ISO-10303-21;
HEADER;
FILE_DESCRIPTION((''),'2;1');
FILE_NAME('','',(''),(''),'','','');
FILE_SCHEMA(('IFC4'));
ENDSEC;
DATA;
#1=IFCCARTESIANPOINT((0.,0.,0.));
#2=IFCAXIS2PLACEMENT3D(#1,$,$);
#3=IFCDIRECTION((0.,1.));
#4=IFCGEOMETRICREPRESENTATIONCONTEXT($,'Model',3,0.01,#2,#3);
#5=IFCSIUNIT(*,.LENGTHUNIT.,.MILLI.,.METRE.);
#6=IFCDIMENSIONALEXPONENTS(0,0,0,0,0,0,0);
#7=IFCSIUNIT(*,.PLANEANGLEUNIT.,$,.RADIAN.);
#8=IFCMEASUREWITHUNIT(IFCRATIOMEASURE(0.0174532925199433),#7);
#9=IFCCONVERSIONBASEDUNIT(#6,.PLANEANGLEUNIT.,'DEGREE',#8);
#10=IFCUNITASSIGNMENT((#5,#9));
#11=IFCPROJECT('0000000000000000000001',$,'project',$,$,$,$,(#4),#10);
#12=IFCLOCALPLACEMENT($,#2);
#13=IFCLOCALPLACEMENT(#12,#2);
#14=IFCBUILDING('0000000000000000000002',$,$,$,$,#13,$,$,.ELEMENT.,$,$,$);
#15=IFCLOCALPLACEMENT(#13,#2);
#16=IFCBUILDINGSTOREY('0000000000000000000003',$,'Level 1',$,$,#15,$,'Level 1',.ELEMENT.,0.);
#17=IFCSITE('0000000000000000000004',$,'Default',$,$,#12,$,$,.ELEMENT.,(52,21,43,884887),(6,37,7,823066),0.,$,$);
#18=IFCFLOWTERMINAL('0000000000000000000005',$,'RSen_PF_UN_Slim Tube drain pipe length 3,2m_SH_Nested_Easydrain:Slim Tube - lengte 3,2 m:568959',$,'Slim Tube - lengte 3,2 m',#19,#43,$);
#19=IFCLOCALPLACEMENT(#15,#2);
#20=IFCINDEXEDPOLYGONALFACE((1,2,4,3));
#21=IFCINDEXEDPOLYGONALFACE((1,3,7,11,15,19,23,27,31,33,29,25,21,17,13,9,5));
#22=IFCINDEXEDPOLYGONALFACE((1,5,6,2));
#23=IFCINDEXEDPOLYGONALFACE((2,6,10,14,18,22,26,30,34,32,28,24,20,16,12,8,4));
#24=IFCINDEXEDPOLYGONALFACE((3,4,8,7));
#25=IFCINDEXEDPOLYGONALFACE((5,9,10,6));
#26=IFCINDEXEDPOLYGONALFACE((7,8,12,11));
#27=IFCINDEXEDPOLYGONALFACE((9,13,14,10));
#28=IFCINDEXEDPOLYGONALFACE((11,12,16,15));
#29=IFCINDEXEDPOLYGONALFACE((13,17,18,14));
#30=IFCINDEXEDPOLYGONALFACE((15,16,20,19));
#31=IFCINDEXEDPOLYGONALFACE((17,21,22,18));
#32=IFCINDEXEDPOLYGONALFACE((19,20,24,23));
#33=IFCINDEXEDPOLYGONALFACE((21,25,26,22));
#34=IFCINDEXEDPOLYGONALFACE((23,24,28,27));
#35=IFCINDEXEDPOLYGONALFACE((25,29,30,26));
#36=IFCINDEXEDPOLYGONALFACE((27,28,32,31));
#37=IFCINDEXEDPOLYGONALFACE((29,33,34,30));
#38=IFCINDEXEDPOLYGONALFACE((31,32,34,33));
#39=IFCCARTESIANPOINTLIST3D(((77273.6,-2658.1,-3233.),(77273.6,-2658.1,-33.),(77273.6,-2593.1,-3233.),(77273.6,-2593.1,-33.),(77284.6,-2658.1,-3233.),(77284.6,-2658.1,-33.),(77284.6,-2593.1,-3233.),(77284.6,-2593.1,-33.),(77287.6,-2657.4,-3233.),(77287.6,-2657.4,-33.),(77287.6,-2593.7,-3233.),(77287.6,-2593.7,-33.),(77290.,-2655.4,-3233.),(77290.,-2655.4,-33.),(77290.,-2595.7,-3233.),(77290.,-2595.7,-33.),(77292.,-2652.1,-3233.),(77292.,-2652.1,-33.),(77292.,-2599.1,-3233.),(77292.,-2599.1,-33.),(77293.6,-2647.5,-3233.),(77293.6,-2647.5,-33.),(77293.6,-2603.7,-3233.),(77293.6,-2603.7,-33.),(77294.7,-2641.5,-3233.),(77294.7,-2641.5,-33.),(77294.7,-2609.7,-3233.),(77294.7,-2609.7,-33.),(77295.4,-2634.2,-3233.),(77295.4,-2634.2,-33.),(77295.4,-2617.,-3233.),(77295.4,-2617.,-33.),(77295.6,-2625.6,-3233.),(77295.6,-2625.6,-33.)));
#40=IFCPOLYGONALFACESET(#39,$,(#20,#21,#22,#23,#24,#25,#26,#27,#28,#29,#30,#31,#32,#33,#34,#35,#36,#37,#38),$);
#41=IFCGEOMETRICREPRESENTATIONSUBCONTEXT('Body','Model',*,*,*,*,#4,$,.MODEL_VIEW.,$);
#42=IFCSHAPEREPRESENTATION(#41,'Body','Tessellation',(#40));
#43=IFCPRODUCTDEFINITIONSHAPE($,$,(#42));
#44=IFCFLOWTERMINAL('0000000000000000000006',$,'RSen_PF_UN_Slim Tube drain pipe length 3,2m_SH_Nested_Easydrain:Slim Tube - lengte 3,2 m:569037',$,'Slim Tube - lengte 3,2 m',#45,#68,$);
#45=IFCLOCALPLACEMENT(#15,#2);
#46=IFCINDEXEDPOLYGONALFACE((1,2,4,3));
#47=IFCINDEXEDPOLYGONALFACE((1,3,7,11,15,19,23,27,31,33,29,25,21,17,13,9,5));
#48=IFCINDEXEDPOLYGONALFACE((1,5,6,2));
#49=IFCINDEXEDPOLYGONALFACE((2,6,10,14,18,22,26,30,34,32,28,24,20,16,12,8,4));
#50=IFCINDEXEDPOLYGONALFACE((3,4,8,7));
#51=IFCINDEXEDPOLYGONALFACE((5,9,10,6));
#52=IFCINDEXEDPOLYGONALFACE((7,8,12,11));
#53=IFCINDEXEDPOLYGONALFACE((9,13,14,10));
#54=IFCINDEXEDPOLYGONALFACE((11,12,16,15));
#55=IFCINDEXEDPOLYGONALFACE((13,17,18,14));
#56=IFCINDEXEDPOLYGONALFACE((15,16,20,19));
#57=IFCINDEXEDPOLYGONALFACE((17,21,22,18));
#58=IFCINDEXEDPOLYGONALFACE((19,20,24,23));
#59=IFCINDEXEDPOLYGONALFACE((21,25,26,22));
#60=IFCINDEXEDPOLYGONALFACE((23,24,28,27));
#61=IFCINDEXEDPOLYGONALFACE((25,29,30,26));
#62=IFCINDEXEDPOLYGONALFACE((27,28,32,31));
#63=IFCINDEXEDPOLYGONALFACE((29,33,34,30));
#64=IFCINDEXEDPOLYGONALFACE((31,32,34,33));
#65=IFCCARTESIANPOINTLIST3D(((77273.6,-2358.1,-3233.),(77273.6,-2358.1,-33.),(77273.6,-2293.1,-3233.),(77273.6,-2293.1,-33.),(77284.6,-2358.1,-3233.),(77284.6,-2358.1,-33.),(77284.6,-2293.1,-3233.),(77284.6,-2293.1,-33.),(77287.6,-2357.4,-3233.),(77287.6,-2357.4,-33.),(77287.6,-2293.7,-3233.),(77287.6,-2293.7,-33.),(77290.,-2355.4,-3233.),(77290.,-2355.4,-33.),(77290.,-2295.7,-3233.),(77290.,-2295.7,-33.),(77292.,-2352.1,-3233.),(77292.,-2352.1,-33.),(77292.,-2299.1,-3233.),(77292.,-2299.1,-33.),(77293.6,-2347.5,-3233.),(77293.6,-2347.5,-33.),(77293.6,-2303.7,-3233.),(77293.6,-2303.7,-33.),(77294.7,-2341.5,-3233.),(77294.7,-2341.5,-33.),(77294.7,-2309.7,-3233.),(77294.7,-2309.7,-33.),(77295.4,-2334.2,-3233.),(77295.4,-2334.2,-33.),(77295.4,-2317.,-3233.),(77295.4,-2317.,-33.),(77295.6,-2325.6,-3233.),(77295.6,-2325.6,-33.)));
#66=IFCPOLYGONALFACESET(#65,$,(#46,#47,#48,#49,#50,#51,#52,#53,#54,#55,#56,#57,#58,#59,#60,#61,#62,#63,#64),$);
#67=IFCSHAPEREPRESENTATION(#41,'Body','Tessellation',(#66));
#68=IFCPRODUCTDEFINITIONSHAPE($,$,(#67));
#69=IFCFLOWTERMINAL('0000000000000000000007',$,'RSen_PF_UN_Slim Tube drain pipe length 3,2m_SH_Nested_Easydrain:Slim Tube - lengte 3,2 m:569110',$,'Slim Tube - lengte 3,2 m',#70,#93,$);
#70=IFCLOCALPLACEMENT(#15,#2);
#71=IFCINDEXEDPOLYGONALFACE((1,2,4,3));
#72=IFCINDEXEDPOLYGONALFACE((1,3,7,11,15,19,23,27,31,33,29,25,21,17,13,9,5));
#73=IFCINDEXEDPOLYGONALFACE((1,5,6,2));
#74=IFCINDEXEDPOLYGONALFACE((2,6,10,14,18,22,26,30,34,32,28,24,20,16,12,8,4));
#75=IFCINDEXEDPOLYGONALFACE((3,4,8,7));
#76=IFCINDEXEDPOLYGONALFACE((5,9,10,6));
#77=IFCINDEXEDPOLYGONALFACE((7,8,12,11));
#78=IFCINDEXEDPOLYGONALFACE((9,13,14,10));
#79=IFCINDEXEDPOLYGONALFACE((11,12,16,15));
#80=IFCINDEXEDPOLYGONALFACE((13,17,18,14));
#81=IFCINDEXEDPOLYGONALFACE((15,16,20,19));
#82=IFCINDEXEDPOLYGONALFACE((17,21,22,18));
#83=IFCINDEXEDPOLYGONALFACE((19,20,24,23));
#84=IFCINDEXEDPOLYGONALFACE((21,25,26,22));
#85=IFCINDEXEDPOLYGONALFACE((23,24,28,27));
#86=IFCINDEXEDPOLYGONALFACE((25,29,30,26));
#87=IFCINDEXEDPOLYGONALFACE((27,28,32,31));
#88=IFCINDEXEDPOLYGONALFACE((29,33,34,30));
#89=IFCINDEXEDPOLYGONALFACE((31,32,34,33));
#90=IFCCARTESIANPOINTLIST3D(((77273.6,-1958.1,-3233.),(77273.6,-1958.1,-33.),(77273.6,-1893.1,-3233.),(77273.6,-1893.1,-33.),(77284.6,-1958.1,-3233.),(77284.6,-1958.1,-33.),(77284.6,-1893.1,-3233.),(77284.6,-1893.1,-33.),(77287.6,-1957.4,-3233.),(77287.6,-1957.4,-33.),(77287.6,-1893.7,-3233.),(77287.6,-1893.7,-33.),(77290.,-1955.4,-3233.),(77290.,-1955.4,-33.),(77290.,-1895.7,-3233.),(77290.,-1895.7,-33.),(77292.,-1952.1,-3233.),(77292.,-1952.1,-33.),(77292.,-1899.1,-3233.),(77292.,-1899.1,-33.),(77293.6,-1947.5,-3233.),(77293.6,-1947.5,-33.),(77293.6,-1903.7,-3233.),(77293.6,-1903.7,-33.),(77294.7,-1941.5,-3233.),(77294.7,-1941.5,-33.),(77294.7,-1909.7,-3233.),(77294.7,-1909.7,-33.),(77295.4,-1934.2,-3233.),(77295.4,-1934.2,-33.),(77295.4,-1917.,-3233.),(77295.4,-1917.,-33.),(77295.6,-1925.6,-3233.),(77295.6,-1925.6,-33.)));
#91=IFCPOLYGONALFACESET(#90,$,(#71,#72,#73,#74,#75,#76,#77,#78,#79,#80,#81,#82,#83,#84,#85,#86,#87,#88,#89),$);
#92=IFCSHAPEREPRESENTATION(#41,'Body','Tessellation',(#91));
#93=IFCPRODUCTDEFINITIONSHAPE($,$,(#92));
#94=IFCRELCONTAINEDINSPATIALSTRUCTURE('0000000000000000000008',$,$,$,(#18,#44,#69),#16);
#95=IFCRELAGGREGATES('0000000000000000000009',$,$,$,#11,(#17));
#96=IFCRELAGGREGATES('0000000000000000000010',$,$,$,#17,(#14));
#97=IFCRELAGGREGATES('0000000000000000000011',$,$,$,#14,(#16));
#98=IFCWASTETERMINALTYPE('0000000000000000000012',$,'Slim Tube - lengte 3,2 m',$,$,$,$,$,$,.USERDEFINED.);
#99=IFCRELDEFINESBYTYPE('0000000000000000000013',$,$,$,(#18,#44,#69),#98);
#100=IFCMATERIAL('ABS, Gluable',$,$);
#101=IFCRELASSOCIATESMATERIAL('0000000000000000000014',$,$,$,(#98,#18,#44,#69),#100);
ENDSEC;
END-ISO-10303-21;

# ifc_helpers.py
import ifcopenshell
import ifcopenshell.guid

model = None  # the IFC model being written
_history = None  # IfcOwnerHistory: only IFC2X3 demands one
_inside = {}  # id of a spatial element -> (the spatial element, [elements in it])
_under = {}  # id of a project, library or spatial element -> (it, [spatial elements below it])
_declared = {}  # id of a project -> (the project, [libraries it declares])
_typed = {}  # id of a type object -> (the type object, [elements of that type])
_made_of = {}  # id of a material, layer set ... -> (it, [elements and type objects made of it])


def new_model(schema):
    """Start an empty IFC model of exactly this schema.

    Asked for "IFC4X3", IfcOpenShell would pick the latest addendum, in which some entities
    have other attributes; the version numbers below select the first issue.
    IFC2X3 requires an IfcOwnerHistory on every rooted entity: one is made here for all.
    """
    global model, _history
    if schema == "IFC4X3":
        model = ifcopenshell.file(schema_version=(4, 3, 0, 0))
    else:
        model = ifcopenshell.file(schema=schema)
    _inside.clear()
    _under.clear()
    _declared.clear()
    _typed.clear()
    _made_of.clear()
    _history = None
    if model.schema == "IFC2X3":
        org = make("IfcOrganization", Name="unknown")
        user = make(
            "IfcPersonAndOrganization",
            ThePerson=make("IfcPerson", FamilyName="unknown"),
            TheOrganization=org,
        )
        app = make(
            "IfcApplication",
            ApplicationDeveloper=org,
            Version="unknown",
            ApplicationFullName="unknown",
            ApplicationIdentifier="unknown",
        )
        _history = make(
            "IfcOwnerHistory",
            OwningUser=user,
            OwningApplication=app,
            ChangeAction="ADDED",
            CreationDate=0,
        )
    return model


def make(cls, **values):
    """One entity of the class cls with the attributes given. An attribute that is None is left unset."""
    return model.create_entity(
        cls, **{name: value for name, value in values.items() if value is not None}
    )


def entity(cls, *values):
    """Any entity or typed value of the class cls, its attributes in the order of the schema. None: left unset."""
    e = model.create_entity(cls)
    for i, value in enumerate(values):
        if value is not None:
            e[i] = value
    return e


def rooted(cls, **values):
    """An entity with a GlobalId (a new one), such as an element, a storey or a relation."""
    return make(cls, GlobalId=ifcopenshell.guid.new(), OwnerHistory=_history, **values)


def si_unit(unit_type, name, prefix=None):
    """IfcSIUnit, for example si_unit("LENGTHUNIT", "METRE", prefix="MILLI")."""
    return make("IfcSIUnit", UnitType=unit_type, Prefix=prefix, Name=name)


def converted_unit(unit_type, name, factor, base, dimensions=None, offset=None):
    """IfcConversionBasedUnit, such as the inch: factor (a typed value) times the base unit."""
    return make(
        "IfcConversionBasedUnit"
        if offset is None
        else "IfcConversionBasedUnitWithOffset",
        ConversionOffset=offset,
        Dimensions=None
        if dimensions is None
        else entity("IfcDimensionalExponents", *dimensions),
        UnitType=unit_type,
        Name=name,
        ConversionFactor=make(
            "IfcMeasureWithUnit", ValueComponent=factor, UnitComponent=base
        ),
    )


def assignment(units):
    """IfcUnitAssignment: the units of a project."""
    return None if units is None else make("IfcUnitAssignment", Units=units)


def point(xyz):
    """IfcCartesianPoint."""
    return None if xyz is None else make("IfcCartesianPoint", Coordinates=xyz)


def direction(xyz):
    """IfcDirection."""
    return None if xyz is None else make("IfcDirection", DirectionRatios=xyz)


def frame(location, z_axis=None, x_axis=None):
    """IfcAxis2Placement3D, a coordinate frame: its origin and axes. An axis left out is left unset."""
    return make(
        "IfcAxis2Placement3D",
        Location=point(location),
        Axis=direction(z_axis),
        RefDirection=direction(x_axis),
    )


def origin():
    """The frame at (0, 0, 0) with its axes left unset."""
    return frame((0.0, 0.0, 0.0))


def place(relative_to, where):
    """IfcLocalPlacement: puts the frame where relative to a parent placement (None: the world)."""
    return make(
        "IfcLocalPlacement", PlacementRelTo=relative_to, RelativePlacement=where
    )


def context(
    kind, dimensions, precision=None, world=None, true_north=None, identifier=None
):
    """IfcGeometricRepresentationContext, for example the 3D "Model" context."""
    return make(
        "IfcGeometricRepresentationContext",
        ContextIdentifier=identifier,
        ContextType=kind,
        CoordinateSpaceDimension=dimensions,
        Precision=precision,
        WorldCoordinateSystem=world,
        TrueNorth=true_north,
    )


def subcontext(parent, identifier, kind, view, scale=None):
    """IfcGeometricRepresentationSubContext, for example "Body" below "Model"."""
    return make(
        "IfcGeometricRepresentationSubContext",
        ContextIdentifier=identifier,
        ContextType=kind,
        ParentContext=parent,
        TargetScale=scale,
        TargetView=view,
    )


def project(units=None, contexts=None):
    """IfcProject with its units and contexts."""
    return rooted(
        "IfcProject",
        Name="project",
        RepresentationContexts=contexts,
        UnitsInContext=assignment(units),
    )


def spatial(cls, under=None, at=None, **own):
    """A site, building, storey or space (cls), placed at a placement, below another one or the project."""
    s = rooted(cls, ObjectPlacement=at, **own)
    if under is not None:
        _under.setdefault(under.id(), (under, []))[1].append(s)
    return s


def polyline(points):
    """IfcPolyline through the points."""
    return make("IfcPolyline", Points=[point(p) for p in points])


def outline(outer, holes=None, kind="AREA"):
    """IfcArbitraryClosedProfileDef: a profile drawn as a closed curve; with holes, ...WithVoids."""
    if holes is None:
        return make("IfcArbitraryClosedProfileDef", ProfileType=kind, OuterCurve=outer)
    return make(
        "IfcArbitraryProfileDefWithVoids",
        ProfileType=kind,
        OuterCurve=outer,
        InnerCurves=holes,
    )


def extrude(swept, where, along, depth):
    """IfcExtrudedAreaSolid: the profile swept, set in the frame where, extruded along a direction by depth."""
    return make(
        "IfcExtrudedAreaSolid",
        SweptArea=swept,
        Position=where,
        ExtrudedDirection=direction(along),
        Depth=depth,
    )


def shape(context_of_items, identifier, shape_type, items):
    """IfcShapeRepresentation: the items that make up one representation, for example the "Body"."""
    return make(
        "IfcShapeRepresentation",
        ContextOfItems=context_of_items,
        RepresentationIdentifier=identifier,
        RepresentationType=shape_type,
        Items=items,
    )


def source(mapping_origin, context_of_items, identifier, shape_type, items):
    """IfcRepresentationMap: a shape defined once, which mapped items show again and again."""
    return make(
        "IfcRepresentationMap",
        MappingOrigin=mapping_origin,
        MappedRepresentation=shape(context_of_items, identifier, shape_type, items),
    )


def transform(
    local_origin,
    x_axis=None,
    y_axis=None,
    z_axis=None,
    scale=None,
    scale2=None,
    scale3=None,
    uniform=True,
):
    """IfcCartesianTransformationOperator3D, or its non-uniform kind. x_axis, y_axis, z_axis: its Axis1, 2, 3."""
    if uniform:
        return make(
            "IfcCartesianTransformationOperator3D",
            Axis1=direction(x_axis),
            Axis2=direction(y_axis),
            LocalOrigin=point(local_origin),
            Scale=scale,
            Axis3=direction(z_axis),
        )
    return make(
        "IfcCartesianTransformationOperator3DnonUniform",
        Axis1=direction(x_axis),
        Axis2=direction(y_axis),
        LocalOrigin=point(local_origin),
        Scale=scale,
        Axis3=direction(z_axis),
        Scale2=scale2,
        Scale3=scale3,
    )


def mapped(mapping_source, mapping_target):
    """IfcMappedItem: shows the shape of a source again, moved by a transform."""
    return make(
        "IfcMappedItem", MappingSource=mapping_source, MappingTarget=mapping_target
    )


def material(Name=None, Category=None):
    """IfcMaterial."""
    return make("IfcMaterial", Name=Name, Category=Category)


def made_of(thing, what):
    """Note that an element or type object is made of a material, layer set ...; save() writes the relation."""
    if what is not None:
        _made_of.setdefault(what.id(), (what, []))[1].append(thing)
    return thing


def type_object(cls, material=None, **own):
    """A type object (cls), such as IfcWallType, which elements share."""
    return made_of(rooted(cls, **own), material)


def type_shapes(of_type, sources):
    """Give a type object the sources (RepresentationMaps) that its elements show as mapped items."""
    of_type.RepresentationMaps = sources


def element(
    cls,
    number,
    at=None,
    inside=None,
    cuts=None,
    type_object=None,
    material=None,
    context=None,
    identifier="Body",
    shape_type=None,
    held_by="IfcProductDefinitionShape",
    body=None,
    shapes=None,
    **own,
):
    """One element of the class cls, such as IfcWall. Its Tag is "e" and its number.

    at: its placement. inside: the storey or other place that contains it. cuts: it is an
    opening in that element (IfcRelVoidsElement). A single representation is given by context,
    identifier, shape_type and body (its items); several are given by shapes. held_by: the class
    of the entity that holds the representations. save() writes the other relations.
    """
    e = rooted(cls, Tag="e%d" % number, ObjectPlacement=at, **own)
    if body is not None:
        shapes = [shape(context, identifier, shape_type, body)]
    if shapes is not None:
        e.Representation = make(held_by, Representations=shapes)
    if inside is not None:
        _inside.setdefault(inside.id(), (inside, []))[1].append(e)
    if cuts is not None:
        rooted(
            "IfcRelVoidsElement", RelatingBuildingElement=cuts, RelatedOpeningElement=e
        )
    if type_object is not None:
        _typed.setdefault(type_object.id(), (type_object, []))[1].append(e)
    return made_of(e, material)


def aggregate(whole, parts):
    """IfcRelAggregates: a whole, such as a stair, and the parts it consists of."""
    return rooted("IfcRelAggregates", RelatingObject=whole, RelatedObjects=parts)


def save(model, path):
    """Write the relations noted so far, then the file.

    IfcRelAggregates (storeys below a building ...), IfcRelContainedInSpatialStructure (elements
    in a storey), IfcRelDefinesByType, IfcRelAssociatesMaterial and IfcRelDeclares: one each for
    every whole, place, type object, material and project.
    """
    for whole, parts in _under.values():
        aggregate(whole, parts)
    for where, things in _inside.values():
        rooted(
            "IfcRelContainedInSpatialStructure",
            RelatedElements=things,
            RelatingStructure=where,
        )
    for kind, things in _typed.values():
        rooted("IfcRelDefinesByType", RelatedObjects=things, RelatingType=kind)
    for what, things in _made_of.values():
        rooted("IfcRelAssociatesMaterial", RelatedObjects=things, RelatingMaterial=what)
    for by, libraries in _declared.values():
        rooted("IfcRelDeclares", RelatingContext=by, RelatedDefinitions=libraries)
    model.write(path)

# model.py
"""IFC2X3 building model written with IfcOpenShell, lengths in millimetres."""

from ifc_helpers import new_model, entity, si_unit, converted_unit, direction, frame, origin, place, context, subcontext, project, spatial, polyline, outline, extrude, source, transform, mapped, material, type_object, type_shapes, element, save


model = new_model("IFC2X3")

# Units and contexts
model_context = context("Model", 3, precision=0.01, world=origin(), true_north=direction((0.0, 1.0)))
body_context = subcontext(model_context, "Body", "Model", "MODEL_VIEW")
ifc_project = project(units=[si_unit("LENGTHUNIT", "METRE", prefix="MILLI"), converted_unit("PLANEANGLEUNIT", "DEGREE", entity("IfcRatioMeasure", 0.0174532925199433), si_unit("PLANEANGLEUNIT", "RADIAN"), dimensions=[0, 0, 0, 0, 0, 0, 0])], contexts=[model_context])

# Site, building, storey
site_placement = place(None, origin())
site = spatial("IfcSite", under=ifc_project, at=site_placement, Name="Default", CompositionType="ELEMENT", RefLatitude=(52, 21, 43, 884887), RefLongitude=(6, 37, 7, 823066), RefElevation=0.0)
building_placement = place(site_placement, origin())
building = spatial("IfcBuilding", under=site, at=building_placement, CompositionType="ELEMENT")
storey_placement = place(building_placement, origin())
storey = spatial("IfcBuildingStorey", under=building, at=storey_placement, Name="Level 1", LongName="Level 1", CompositionType="ELEMENT", Elevation=0.0)

# Flow terminals
ifc_material_1 = material(Name="ABS, Gluable")
waste_terminal_type_1 = type_object("IfcWasteTerminalType", Name="Slim Tube - lengte 3,2 m", PredefinedType="USERDEFINED", material=ifc_material_1)
shared_shape_1 = source(origin(), body_context, "Body", "SweptSolid", [
    extrude(outline(polyline([(4.7, -32.5), (15.7, -32.5), (15.7, 32.5), (4.7, 32.5), (1.8, 31.8), (-0.7, 29.8), (-2.7, 26.5), (-4.3, 21.9), (-5.4, 15.9), (-6.1, 8.6), (-6.3, 0.0), (-6.1, -8.6), (-5.4, -15.9), (-4.3, -21.9), (-2.7, -26.5), (-0.7, -29.8), (1.8, -31.8), (4.7, -32.5)])), frame((4.7, 0.0, -3200.0), z_axis=(0.0, 0.0, 1.0), x_axis=(-1.0, 0.0, 0.0)), (0.0, 0.0, 1.0), 3200.0),
])
type_shapes(waste_terminal_type_1, [shared_shape_1])
for number, where, name in (
    (1, (77284.6, -2625.6, -33.0), "RSen_PF_UN_Slim Tube drain pipe length 3,2m_SH_Nested_Easydrain:Slim Tube - lengte 3,2 m:568959"),
    (2, (77284.6, -2325.6, -33.0), "RSen_PF_UN_Slim Tube drain pipe length 3,2m_SH_Nested_Easydrain:Slim Tube - lengte 3,2 m:569037"),
    (3, (77284.6, -1925.6, -33.0), "RSen_PF_UN_Slim Tube drain pipe length 3,2m_SH_Nested_Easydrain:Slim Tube - lengte 3,2 m:569110"),
):
    element("IfcFlowTerminal", number, at=place(storey_placement, frame(where)), inside=storey, type_object=waste_terminal_type_1, material=ifc_material_1, Name=name, ObjectType="Slim Tube - lengte 3,2 m", context=body_context, shape_type="MappedRepresentation", body=[
        mapped(shared_shape_1, transform((0.0, 0.0, 0.0), scale=1.0)),
    ])

save(model, "model.ifc")
